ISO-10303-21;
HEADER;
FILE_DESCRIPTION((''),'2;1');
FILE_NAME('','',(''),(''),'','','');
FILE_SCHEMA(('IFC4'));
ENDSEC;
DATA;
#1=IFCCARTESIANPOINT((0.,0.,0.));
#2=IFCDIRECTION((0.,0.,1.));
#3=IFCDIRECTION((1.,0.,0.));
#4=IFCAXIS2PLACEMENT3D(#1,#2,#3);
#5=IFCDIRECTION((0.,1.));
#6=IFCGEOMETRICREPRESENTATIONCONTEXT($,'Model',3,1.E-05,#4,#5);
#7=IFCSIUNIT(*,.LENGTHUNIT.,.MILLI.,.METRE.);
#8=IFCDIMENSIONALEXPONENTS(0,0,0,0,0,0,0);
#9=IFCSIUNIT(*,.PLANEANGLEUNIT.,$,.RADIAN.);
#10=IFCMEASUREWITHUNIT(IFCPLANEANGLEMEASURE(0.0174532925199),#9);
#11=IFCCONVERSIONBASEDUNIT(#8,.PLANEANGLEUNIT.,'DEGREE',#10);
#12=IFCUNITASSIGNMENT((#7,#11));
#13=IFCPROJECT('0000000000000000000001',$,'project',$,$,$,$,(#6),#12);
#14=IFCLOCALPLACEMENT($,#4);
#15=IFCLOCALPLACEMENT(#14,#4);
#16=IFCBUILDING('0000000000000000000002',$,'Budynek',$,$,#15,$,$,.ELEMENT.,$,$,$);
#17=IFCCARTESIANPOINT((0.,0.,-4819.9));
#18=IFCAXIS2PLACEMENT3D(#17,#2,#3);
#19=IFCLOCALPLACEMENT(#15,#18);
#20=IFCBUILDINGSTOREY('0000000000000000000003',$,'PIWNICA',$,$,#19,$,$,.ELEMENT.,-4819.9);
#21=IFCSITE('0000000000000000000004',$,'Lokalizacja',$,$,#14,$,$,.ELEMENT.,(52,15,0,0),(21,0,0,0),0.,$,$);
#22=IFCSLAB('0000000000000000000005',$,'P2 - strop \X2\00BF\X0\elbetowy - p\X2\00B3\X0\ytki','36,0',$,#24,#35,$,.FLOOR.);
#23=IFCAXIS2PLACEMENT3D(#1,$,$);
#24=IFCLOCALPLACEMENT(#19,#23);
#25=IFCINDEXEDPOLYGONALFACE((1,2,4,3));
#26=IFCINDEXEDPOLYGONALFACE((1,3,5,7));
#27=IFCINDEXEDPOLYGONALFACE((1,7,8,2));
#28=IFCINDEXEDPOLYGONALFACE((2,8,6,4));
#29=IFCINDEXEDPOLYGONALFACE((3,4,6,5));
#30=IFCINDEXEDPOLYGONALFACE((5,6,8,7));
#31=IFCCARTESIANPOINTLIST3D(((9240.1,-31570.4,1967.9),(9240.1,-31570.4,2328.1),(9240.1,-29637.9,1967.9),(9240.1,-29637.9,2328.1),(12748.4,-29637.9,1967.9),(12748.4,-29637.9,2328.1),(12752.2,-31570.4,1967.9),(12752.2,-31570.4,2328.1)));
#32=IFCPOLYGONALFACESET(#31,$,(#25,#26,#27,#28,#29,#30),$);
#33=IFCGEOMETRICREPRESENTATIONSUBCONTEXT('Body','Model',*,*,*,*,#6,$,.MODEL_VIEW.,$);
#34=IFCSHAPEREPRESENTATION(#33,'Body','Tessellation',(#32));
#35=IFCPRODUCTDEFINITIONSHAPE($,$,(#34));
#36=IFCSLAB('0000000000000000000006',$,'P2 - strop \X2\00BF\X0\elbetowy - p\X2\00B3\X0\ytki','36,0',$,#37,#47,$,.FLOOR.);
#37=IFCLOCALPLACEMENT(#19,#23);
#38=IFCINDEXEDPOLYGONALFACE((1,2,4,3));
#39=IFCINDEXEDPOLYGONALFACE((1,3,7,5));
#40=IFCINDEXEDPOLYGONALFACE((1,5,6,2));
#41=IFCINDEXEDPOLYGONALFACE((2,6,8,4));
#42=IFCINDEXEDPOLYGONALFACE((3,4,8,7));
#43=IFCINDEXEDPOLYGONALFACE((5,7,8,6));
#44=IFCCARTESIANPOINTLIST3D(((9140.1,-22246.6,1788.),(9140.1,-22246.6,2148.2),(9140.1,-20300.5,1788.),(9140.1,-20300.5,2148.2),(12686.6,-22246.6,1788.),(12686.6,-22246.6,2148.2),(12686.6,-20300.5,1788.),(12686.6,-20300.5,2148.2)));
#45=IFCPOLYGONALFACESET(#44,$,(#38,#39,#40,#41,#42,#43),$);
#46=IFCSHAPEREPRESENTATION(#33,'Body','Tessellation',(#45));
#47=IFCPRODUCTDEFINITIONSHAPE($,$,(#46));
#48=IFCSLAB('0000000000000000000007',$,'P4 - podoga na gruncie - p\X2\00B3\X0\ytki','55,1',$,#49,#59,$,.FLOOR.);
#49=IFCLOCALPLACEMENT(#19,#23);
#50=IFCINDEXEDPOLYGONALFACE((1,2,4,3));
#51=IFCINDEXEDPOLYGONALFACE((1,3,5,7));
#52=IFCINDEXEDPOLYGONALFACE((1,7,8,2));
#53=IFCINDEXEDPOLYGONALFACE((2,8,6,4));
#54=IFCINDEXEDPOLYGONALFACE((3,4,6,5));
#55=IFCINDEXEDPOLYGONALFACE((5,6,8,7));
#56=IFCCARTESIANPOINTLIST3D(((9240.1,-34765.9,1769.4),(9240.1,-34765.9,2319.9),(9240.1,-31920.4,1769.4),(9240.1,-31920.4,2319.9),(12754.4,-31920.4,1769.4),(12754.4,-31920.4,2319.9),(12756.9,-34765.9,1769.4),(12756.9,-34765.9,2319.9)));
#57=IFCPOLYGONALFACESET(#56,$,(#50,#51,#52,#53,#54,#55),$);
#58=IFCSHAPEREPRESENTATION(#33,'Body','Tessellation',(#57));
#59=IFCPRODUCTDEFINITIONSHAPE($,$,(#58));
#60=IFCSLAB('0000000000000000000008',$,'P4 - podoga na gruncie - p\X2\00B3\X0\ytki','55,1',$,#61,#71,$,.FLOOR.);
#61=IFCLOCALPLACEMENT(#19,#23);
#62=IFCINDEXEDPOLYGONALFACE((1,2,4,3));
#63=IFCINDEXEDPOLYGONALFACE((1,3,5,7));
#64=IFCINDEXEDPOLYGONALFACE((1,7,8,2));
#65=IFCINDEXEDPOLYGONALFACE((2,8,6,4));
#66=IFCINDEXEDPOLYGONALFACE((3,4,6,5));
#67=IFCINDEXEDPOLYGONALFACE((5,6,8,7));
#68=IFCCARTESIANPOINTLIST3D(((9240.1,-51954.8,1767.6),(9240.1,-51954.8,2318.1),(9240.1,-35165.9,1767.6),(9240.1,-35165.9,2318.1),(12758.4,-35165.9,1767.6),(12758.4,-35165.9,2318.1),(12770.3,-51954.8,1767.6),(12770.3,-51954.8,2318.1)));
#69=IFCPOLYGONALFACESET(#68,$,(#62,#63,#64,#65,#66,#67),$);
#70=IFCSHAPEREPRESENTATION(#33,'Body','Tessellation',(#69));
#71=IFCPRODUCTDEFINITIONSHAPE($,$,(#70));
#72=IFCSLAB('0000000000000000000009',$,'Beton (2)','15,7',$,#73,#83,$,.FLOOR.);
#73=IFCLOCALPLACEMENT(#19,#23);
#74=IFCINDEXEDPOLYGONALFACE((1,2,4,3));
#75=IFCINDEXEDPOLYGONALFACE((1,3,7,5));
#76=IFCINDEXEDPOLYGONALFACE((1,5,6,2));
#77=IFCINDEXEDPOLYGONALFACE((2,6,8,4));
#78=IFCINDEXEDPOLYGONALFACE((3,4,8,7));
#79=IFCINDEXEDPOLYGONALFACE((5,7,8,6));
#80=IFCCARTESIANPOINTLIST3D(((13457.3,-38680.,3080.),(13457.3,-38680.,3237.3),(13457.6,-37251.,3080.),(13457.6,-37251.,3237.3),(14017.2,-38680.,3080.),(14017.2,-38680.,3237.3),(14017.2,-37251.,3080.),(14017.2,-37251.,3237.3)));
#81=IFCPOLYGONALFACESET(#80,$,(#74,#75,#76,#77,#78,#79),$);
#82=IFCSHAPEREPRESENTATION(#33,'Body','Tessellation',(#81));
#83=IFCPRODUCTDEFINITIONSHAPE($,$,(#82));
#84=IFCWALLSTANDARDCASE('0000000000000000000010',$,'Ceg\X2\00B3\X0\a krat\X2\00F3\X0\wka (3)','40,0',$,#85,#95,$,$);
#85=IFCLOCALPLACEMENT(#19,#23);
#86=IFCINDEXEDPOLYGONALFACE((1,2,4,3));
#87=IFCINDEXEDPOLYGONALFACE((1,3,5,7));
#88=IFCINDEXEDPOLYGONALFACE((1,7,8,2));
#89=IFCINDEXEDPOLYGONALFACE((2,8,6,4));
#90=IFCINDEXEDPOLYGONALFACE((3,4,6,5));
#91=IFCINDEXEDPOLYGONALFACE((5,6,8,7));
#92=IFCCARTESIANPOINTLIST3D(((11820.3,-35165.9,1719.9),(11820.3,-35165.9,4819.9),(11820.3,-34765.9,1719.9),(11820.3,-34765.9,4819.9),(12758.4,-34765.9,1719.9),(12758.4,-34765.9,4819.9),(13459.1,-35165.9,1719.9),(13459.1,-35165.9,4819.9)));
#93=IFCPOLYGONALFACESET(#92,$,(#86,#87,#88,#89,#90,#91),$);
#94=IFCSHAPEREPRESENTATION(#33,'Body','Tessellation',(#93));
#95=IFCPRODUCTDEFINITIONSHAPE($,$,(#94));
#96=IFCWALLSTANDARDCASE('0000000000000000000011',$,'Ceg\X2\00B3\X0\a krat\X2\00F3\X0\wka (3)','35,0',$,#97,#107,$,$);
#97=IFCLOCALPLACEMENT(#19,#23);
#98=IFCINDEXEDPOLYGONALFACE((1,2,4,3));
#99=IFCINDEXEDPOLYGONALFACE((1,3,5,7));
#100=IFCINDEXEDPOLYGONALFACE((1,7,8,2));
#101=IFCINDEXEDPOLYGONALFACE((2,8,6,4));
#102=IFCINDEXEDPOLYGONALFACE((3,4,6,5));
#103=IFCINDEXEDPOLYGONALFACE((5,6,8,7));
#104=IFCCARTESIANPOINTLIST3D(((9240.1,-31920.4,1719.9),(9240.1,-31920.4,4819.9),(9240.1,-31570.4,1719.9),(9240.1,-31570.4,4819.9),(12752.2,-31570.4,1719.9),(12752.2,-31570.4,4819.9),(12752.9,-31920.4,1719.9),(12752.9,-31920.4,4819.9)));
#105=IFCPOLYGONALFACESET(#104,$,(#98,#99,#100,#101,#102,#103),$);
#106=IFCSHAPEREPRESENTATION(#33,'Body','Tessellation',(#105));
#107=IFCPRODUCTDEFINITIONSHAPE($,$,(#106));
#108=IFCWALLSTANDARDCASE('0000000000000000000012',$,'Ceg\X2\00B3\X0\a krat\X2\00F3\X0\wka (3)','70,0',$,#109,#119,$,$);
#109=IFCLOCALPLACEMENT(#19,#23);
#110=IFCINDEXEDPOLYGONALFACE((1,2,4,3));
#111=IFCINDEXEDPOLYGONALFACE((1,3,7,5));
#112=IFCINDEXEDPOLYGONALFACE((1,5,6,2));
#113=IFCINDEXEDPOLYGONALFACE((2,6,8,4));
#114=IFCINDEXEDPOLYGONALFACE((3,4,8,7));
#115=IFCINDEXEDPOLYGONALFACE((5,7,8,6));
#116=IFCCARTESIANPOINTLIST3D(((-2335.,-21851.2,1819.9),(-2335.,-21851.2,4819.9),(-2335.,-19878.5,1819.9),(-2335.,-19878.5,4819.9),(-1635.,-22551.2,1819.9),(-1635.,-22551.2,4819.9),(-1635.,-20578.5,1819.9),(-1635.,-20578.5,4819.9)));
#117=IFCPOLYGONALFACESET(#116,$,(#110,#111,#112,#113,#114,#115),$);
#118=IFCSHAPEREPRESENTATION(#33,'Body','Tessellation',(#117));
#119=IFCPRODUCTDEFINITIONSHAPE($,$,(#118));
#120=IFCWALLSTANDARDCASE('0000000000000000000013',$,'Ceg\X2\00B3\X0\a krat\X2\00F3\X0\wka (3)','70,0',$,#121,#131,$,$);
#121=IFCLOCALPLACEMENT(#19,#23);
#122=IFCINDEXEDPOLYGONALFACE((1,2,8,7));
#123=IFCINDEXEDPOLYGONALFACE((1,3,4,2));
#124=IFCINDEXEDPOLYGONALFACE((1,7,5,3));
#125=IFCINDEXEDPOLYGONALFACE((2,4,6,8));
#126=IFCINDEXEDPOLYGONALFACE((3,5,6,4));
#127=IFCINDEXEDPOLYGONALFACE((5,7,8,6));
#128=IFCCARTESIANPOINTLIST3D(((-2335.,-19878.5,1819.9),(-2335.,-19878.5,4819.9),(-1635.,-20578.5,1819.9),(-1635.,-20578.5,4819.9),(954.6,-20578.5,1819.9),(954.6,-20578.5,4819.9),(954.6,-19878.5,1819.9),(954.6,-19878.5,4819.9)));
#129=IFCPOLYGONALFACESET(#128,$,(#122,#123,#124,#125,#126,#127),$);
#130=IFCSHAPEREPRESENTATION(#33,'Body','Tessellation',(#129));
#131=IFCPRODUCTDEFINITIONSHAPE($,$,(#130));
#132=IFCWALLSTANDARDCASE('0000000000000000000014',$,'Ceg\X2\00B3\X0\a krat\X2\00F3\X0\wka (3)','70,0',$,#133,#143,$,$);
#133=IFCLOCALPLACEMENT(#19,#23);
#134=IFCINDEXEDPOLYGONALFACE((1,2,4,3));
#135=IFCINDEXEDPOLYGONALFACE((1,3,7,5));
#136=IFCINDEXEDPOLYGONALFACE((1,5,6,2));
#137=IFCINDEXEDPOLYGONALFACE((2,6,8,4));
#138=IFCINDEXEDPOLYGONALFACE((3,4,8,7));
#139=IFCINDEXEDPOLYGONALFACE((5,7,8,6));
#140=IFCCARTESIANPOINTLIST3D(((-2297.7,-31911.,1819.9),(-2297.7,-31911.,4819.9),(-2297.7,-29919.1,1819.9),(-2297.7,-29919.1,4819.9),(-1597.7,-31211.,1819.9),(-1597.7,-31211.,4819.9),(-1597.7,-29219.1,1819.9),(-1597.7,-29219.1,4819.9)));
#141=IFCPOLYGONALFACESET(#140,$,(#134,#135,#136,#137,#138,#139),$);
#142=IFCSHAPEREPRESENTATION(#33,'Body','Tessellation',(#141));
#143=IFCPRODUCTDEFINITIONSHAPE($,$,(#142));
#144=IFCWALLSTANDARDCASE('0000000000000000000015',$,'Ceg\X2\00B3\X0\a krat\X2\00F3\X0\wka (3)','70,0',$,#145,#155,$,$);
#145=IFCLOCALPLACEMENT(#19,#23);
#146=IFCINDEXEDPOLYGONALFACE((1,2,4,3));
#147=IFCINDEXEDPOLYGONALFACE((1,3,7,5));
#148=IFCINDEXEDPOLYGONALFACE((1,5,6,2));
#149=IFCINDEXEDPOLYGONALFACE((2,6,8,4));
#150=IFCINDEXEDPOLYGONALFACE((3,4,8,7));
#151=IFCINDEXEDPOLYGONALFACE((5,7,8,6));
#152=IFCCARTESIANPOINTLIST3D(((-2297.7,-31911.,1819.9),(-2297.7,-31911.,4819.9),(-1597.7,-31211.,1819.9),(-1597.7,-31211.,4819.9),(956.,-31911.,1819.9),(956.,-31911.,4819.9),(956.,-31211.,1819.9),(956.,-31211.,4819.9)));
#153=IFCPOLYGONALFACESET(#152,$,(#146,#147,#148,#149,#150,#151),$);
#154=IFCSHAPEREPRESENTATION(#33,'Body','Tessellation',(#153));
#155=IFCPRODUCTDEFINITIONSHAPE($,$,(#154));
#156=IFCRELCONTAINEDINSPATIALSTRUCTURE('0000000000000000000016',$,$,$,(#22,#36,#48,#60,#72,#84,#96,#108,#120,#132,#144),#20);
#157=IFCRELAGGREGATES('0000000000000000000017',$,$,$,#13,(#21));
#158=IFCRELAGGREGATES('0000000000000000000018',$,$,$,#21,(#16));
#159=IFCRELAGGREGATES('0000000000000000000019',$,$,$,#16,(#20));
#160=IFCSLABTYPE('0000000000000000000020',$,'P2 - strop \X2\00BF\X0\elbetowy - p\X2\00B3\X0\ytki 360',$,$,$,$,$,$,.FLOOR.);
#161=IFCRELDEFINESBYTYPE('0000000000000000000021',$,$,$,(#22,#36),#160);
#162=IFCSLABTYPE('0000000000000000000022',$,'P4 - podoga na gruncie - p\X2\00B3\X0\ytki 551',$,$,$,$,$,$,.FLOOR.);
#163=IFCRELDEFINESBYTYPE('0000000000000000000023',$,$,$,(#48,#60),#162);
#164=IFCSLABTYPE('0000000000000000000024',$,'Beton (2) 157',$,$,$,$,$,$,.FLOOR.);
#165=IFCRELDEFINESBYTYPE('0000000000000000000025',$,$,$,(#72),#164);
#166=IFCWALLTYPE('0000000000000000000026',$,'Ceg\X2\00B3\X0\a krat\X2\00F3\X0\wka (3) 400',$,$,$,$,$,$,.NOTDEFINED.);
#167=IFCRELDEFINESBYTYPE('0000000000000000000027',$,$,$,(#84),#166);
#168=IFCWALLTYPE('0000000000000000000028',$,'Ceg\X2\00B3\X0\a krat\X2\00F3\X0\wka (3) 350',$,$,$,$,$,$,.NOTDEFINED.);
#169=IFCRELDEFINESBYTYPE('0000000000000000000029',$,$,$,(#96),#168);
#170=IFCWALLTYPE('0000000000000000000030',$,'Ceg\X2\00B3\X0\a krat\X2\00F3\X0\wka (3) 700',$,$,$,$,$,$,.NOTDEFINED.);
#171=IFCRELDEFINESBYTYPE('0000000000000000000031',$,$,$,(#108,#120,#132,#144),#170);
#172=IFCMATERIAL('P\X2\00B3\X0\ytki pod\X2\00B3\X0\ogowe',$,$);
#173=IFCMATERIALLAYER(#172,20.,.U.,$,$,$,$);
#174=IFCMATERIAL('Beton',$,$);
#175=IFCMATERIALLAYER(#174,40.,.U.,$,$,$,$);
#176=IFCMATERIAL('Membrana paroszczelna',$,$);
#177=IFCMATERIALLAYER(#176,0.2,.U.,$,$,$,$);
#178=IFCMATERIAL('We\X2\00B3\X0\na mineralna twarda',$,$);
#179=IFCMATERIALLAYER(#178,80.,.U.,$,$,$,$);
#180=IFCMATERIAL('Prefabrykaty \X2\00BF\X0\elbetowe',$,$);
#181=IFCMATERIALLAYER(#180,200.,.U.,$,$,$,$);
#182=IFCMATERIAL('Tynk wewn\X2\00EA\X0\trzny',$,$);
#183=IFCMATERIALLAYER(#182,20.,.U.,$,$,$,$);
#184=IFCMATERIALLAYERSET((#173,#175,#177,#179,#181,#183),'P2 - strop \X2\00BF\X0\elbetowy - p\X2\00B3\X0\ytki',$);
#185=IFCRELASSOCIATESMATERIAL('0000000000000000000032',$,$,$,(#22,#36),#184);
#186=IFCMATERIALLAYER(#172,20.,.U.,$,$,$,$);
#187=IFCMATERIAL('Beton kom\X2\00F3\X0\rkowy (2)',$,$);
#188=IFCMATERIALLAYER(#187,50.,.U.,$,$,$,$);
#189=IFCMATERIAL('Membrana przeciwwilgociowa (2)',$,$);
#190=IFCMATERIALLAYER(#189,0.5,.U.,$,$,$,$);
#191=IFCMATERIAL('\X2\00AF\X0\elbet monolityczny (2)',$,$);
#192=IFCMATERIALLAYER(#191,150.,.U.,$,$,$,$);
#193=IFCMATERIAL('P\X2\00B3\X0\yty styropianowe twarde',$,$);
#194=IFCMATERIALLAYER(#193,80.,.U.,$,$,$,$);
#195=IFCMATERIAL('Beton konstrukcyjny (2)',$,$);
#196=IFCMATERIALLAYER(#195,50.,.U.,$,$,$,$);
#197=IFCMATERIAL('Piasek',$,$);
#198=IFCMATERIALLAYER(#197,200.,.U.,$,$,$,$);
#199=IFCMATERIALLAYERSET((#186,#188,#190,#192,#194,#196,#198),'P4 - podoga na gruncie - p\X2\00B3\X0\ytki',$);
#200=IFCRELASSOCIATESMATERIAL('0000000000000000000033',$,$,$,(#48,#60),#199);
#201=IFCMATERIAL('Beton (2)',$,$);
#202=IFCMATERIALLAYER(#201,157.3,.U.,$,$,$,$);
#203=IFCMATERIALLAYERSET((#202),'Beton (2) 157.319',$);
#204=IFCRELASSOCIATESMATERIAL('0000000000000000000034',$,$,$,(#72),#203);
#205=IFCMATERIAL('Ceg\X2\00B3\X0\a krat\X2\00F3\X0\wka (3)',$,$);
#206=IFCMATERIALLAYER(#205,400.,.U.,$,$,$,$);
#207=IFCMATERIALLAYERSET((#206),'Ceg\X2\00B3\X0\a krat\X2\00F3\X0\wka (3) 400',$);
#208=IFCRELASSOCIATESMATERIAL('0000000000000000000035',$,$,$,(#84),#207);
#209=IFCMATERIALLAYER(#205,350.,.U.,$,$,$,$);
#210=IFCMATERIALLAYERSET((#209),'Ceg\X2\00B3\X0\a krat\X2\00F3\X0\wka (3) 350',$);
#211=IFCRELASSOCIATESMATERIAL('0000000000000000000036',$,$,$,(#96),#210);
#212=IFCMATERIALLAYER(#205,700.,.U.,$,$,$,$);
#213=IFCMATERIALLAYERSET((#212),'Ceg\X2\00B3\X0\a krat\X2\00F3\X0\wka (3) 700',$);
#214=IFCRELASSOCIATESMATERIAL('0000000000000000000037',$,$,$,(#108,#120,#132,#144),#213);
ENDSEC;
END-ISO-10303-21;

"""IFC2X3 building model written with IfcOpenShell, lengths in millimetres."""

from ifc_helpers import new_model, entity, si_unit, converted_unit, direction, frame, origin_with_axes, place, context, subcontext, project, spatial, polyline, outline, extrude, material, layer, layer_set, layer_usage, type_object, element, save


model = new_model("IFC2X3")

# Units and contexts
model_context = context("Model", 3, precision=1e-05, world=origin_with_axes(), true_north=direction((0.0, 1.0)))
body_context = subcontext(model_context, "Body", "Model", "MODEL_VIEW")
ifc_project = project(units=[si_unit("LENGTHUNIT", "METRE", prefix="MILLI"), converted_unit("PLANEANGLEUNIT", "DEGREE", entity("IfcPlaneAngleMeasure", 0.0174532925199), si_unit("PLANEANGLEUNIT", "RADIAN"), dimensions=[0, 0, 0, 0, 0, 0, 0])], contexts=[model_context])

# Site, building, storey
site_placement = place(None, origin_with_axes())
site = spatial("IfcSite", under=ifc_project, at=site_placement, Name="Lokalizacja", CompositionType="ELEMENT", RefLatitude=(52, 15, 0, 0), RefLongitude=(21, 0, 0, 0), RefElevation=0.0)
building_placement = place(site_placement, origin_with_axes())
building = spatial("IfcBuilding", under=site, at=building_placement, Name="Budynek", CompositionType="ELEMENT")
storey_placement = place(building_placement, frame((0.0, 0.0, -4819.9), z_axis=(0.0, 0.0, 1.0), x_axis=(1.0, 0.0, 0.0)))
storey = spatial("IfcBuildingStorey", under=building, at=storey_placement, Name="PIWNICA", CompositionType="ELEMENT", Elevation=-4819.9)

# Slabs
ifc_material_1 = material(Name="P³ytki pod³ogowe")
ifc_layer_1 = layer(ifc_material_1, 20.0, ventilated="UNKNOWN")
ifc_material_2 = material(Name="Beton")
ifc_layer_2 = layer(ifc_material_2, 40.0, ventilated="UNKNOWN")
ifc_material_3 = material(Name="Membrana paroszczelna")
ifc_layer_3 = layer(ifc_material_3, 0.2, ventilated="UNKNOWN")
ifc_material_4 = material(Name="We³na mineralna twarda")
ifc_layer_4 = layer(ifc_material_4, 80.0, ventilated="UNKNOWN")
ifc_material_5 = material(Name="Prefabrykaty ¿elbetowe")
ifc_layer_5 = layer(ifc_material_5, 200.0, ventilated="UNKNOWN")
ifc_material_6 = material(Name="Tynk wewnêtrzny")
ifc_layer_6 = layer(ifc_material_6, 20.0, ventilated="UNKNOWN")
ifc_layer_set_1 = layer_set([ifc_layer_1, ifc_layer_2, ifc_layer_3, ifc_layer_4, ifc_layer_5, ifc_layer_6], Name="P2 - strop ¿elbetowy - p³ytki")
ifc_layer_usage_1 = layer_usage(ifc_layer_set_1, "AXIS3", "NEGATIVE", 360.2)
slab_type_1 = type_object("IfcSlabType", Name="P2 - strop ¿elbetowy - p³ytki 360", PredefinedType="FLOOR")
slab_1_placement = place(storey_placement, frame((9240.1, -29637.9, 2328.1), z_axis=(0.0, 0.0, 1.0), x_axis=(1.0, 0.0, 0.0)))
element("IfcSlab", 1, at=slab_1_placement, inside=storey, type_object=slab_type_1, material=ifc_layer_usage_1, Name="P2 - strop ¿elbetowy - p³ytki", Description="36,0", PredefinedType="FLOOR", context=body_context, shape_type="SweptSolid", body=[
    extrude(outline(polyline([(0.0, 0.0), (0.0, -1932.5), (3512.0, -1932.5), (3508.3, 0.0), (0.0, 0.0)])), frame((0.0, 0.0, -360.2), z_axis=(0.0, 0.0, 1.0), x_axis=(1.0, 0.0, 0.0)), (0.0, 0.0, 1.0), 360.2),
])
ifc_layer_usage_2 = layer_usage(ifc_layer_set_1, "AXIS3", "NEGATIVE", 360.2)
slab_2_placement = place(storey_placement, frame((9140.1, -20300.5, 2148.2), z_axis=(0.0, 0.0, 1.0), x_axis=(1.0, 0.0, 0.0)))
element("IfcSlab", 2, at=slab_2_placement, inside=storey, type_object=slab_type_1, material=ifc_layer_usage_2, Name="P2 - strop ¿elbetowy - p³ytki", Description="36,0", PredefinedType="FLOOR", context=body_context, shape_type="SweptSolid", body=[
    extrude(outline(polyline([(0.0, 0.0), (0.0, -1946.2), (3546.4, -1946.2), (3546.4, 0.0), (0.0, 0.0)])), frame((0.0, 0.0, -360.2), z_axis=(0.0, 0.0, 1.0), x_axis=(1.0, 0.0, 0.0)), (0.0, 0.0, 1.0), 360.2),
])
ifc_layer_7 = layer(ifc_material_1, 20.0, ventilated="UNKNOWN")
ifc_material_7 = material(Name="Beton komórkowy (2)")
ifc_layer_8 = layer(ifc_material_7, 50.0, ventilated="UNKNOWN")
ifc_material_8 = material(Name="Membrana przeciwwilgociowa (2)")
ifc_layer_9 = layer(ifc_material_8, 0.5, ventilated="UNKNOWN")
ifc_material_9 = material(Name="¯elbet monolityczny (2)")
ifc_layer_10 = layer(ifc_material_9, 150.0, ventilated="UNKNOWN")
ifc_material_10 = material(Name="P³yty styropianowe twarde")
ifc_layer_11 = layer(ifc_material_10, 80.0, ventilated="UNKNOWN")
ifc_material_11 = material(Name="Beton konstrukcyjny (2)")
ifc_layer_12 = layer(ifc_material_11, 50.0, ventilated="UNKNOWN")
ifc_material_12 = material(Name="Piasek")
ifc_layer_13 = layer(ifc_material_12, 200.0, ventilated="UNKNOWN")
ifc_layer_set_2 = layer_set([ifc_layer_7, ifc_layer_8, ifc_layer_9, ifc_layer_10, ifc_layer_11, ifc_layer_12, ifc_layer_13], Name="P4 - podoga na gruncie - p³ytki")
ifc_layer_usage_3 = layer_usage(ifc_layer_set_2, "AXIS3", "NEGATIVE", 550.5)
slab_type_2 = type_object("IfcSlabType", Name="P4 - podoga na gruncie - p³ytki 551", PredefinedType="FLOOR")
slab_3_placement = place(storey_placement, frame((9240.1, -31920.4, 2319.9), z_axis=(0.0, 0.0, 1.0), x_axis=(1.0, 0.0, 0.0)))
element("IfcSlab", 3, at=slab_3_placement, inside=storey, type_object=slab_type_2, material=ifc_layer_usage_3, Name="P4 - podoga na gruncie - p³ytki", Description="55,1", PredefinedType="FLOOR", context=body_context, shape_type="SweptSolid", body=[
    extrude(outline(polyline([(0.0, 0.0), (0.0, -2845.5), (3516.8, -2845.5), (3514.2, 0.0), (0.0, 0.0)])), frame((0.0, 0.0, -550.5), z_axis=(0.0, 0.0, 1.0), x_axis=(1.0, 0.0, 0.0)), (0.0, 0.0, 1.0), 550.5),
])
ifc_layer_usage_4 = layer_usage(ifc_layer_set_2, "AXIS3", "NEGATIVE", 550.5)
slab_4_placement = place(storey_placement, frame((9240.1, -35165.9, 2318.1), z_axis=(0.0, 0.0, 1.0), x_axis=(1.0, 0.0, 0.0)))
element("IfcSlab", 4, at=slab_4_placement, inside=storey, type_object=slab_type_2, material=ifc_layer_usage_4, Name="P4 - podoga na gruncie - p³ytki", Description="55,1", PredefinedType="FLOOR", context=body_context, shape_type="SweptSolid", body=[
    extrude(outline(polyline([(0.0, 0.0), (0.0, -16788.9), (3530.2, -16788.9), (3518.2, 0.0), (0.0, 0.0)])), frame((0.0, 0.0, -550.5), z_axis=(0.0, 0.0, 1.0), x_axis=(1.0, 0.0, 0.0)), (0.0, 0.0, 1.0), 550.5),
])
ifc_material_13 = material(Name="Beton (2)")
ifc_layer_14 = layer(ifc_material_13, 157.3, ventilated="UNKNOWN")
ifc_layer_set_3 = layer_set([ifc_layer_14], Name="Beton (2) 157.319")
ifc_layer_usage_5 = layer_usage(ifc_layer_set_3, "AXIS3", "NEGATIVE", 157.3)
slab_type_3 = type_object("IfcSlabType", Name="Beton (2) 157", PredefinedType="FLOOR")
slab_5_placement = place(storey_placement, frame((13457.6, -37251.0, 3237.3), z_axis=(0.0, 0.0, 1.0), x_axis=(1.0, 0.0, 0.0)))
element("IfcSlab", 5, at=slab_5_placement, inside=storey, type_object=slab_type_3, material=ifc_layer_usage_5, Name="Beton (2)", Description="15,7", PredefinedType="FLOOR", context=body_context, shape_type="SweptSolid", body=[
    extrude(outline(polyline([(0.0, 0.0), (-0.3, -1429.0), (559.6, -1429.0), (559.6, 0.0), (0.0, 0.0)])), frame((0.0, 0.0, -157.3), z_axis=(0.0, 0.0, 1.0), x_axis=(1.0, 0.0, 0.0)), (0.0, 0.0, 1.0), 157.3),
])

# Wall
ifc_material_14 = material(Name="Ceg³a kratówka (3)")
ifc_layer_15 = layer(ifc_material_14, 400.0, ventilated="UNKNOWN")
ifc_layer_set_4 = layer_set([ifc_layer_15], Name="Ceg³a kratówka (3) 400")
ifc_layer_usage_6 = layer_usage(ifc_layer_set_4, "AXIS2", "POSITIVE", 0.0)
wall_type_1 = type_object("IfcWallType", Name="Ceg³a kratówka (3) 400", PredefinedType="NOTDEFINED")
wall_1_placement = place(storey_placement, frame((12758.4, -34765.9, 1719.9), z_axis=(0.0, 0.0, 1.0), x_axis=(-1.0, 0.0, 0.0)))
element("IfcWallStandardCase", 6, at=wall_1_placement, inside=storey, type_object=wall_type_1, material=ifc_layer_usage_6, Name="Ceg³a kratówka (3)", Description="40,0", context=body_context, shape_type="SweptSolid", body=[
    extrude(outline(polyline([(0.0, 0.0), (938.1, 0.0), (938.1, 400.0), (-700.8, 400.0), (0.0, 0.0)])), origin_with_axes(), (0.0, 0.0, 1.0), 3100.0),
])

# Walls
ifc_layer_16 = layer(ifc_material_14, 350.0, ventilated="UNKNOWN")
ifc_layer_set_5 = layer_set([ifc_layer_16], Name="Ceg³a kratówka (3) 350")
ifc_layer_usage_7 = layer_usage(ifc_layer_set_5, "AXIS2", "NEGATIVE", 0.0)
wall_type_2 = type_object("IfcWallType", Name="Ceg³a kratówka (3) 350", PredefinedType="NOTDEFINED")
wall_2_placement = place(storey_placement, frame((12752.9, -31920.4, 1719.9), z_axis=(0.0, 0.0, 1.0), x_axis=(-1.0, 0.0, 0.0)))
element("IfcWallStandardCase", 7, at=wall_2_placement, inside=storey, type_object=wall_type_2, material=ifc_layer_usage_7, Name="Ceg³a kratówka (3)", Description="35,0", context=body_context, shape_type="SweptSolid", body=[
    extrude(outline(polyline([(0.7, -350.0), (3512.7, -350.0), (3512.7, 0.0), (0.0, 0.0), (0.7, -350.0)])), origin_with_axes(), (0.0, 0.0, 1.0), 3100.0),
])
ifc_layer_17 = layer(ifc_material_14, 700.0, ventilated="UNKNOWN")
ifc_layer_set_6 = layer_set([ifc_layer_17], Name="Ceg³a kratówka (3) 700")
ifc_layer_usage_8 = layer_usage(ifc_layer_set_6, "AXIS2", "NEGATIVE", 0.0)
wall_type_3 = type_object("IfcWallType", Name="Ceg³a kratówka (3) 700", PredefinedType="NOTDEFINED")
wall_3_placement = place(storey_placement, frame((-1635.0, -20578.5, 1819.9), z_axis=(0.0, 0.0, 1.0), x_axis=(0.0, -1.0, 0.0)))
element("IfcWallStandardCase", 8, at=wall_3_placement, inside=storey, type_object=wall_type_3, material=ifc_layer_usage_8, Name="Ceg³a kratówka (3)", Description="70,0", context=body_context, shape_type="SweptSolid", body=[
    extrude(outline(polyline([(-700.0, -700.0), (1272.6, -700.0), (1972.6, 0.0), (0.0, 0.0), (-700.0, -700.0)])), origin_with_axes(), (0.0, 0.0, 1.0), 3000.0),
])
ifc_layer_usage_9 = layer_usage(ifc_layer_set_6, "AXIS2", "NEGATIVE", 0.0)
wall_4_placement = place(storey_placement, frame((954.6, -20578.5, 1819.9), z_axis=(0.0, 0.0, 1.0), x_axis=(-1.0, 0.0, 0.0)))
element("IfcWallStandardCase", 9, at=wall_4_placement, inside=storey, type_object=wall_type_3, material=ifc_layer_usage_9, Name="Ceg³a kratówka (3)", Description="70,0", context=body_context, shape_type="SweptSolid", body=[
    extrude(outline(polyline([(0.0, -700.0), (3289.6, -700.0), (2589.6, 0.0), (0.0, 0.0), (0.0, -700.0)])), origin_with_axes(), (0.0, 0.0, 1.0), 3000.0),
])
ifc_layer_usage_10 = layer_usage(ifc_layer_set_6, "AXIS2", "NEGATIVE", 0.0)
wall_5_placement = place(storey_placement, frame((-1597.7, -29219.1, 1819.9), z_axis=(0.0, 0.0, 1.0), x_axis=(0.0, -1.0, 0.0)))
element("IfcWallStandardCase", 10, at=wall_5_placement, inside=storey, type_object=wall_type_3, material=ifc_layer_usage_10, Name="Ceg³a kratówka (3)", Description="70,0", context=body_context, shape_type="SweptSolid", body=[
    extrude(outline(polyline([(700.0, -700.0), (2691.9, -700.0), (1991.9, 0.0), (0.0, 0.0), (700.0, -700.0)])), origin_with_axes(), (0.0, 0.0, 1.0), 3000.0),
])
ifc_layer_usage_11 = layer_usage(ifc_layer_set_6, "AXIS2", "NEGATIVE", 0.0)
wall_6_placement = place(storey_placement, frame((-1597.7, -31211.0, 1819.9), z_axis=(0.0, 0.0, 1.0), x_axis=(1.0, 0.0, 0.0)))
element("IfcWallStandardCase", 11, at=wall_6_placement, inside=storey, type_object=wall_type_3, material=ifc_layer_usage_11, Name="Ceg³a kratówka (3)", Description="70,0", context=body_context, shape_type="SweptSolid", body=[
    extrude(outline(polyline([(-700.0, -700.0), (2553.8, -700.0), (2553.8, 0.0), (0.0, 0.0), (-700.0, -700.0)])), origin_with_axes(), (0.0, 0.0, 1.0), 3000.0),
])

save(model, "model.ifc")
